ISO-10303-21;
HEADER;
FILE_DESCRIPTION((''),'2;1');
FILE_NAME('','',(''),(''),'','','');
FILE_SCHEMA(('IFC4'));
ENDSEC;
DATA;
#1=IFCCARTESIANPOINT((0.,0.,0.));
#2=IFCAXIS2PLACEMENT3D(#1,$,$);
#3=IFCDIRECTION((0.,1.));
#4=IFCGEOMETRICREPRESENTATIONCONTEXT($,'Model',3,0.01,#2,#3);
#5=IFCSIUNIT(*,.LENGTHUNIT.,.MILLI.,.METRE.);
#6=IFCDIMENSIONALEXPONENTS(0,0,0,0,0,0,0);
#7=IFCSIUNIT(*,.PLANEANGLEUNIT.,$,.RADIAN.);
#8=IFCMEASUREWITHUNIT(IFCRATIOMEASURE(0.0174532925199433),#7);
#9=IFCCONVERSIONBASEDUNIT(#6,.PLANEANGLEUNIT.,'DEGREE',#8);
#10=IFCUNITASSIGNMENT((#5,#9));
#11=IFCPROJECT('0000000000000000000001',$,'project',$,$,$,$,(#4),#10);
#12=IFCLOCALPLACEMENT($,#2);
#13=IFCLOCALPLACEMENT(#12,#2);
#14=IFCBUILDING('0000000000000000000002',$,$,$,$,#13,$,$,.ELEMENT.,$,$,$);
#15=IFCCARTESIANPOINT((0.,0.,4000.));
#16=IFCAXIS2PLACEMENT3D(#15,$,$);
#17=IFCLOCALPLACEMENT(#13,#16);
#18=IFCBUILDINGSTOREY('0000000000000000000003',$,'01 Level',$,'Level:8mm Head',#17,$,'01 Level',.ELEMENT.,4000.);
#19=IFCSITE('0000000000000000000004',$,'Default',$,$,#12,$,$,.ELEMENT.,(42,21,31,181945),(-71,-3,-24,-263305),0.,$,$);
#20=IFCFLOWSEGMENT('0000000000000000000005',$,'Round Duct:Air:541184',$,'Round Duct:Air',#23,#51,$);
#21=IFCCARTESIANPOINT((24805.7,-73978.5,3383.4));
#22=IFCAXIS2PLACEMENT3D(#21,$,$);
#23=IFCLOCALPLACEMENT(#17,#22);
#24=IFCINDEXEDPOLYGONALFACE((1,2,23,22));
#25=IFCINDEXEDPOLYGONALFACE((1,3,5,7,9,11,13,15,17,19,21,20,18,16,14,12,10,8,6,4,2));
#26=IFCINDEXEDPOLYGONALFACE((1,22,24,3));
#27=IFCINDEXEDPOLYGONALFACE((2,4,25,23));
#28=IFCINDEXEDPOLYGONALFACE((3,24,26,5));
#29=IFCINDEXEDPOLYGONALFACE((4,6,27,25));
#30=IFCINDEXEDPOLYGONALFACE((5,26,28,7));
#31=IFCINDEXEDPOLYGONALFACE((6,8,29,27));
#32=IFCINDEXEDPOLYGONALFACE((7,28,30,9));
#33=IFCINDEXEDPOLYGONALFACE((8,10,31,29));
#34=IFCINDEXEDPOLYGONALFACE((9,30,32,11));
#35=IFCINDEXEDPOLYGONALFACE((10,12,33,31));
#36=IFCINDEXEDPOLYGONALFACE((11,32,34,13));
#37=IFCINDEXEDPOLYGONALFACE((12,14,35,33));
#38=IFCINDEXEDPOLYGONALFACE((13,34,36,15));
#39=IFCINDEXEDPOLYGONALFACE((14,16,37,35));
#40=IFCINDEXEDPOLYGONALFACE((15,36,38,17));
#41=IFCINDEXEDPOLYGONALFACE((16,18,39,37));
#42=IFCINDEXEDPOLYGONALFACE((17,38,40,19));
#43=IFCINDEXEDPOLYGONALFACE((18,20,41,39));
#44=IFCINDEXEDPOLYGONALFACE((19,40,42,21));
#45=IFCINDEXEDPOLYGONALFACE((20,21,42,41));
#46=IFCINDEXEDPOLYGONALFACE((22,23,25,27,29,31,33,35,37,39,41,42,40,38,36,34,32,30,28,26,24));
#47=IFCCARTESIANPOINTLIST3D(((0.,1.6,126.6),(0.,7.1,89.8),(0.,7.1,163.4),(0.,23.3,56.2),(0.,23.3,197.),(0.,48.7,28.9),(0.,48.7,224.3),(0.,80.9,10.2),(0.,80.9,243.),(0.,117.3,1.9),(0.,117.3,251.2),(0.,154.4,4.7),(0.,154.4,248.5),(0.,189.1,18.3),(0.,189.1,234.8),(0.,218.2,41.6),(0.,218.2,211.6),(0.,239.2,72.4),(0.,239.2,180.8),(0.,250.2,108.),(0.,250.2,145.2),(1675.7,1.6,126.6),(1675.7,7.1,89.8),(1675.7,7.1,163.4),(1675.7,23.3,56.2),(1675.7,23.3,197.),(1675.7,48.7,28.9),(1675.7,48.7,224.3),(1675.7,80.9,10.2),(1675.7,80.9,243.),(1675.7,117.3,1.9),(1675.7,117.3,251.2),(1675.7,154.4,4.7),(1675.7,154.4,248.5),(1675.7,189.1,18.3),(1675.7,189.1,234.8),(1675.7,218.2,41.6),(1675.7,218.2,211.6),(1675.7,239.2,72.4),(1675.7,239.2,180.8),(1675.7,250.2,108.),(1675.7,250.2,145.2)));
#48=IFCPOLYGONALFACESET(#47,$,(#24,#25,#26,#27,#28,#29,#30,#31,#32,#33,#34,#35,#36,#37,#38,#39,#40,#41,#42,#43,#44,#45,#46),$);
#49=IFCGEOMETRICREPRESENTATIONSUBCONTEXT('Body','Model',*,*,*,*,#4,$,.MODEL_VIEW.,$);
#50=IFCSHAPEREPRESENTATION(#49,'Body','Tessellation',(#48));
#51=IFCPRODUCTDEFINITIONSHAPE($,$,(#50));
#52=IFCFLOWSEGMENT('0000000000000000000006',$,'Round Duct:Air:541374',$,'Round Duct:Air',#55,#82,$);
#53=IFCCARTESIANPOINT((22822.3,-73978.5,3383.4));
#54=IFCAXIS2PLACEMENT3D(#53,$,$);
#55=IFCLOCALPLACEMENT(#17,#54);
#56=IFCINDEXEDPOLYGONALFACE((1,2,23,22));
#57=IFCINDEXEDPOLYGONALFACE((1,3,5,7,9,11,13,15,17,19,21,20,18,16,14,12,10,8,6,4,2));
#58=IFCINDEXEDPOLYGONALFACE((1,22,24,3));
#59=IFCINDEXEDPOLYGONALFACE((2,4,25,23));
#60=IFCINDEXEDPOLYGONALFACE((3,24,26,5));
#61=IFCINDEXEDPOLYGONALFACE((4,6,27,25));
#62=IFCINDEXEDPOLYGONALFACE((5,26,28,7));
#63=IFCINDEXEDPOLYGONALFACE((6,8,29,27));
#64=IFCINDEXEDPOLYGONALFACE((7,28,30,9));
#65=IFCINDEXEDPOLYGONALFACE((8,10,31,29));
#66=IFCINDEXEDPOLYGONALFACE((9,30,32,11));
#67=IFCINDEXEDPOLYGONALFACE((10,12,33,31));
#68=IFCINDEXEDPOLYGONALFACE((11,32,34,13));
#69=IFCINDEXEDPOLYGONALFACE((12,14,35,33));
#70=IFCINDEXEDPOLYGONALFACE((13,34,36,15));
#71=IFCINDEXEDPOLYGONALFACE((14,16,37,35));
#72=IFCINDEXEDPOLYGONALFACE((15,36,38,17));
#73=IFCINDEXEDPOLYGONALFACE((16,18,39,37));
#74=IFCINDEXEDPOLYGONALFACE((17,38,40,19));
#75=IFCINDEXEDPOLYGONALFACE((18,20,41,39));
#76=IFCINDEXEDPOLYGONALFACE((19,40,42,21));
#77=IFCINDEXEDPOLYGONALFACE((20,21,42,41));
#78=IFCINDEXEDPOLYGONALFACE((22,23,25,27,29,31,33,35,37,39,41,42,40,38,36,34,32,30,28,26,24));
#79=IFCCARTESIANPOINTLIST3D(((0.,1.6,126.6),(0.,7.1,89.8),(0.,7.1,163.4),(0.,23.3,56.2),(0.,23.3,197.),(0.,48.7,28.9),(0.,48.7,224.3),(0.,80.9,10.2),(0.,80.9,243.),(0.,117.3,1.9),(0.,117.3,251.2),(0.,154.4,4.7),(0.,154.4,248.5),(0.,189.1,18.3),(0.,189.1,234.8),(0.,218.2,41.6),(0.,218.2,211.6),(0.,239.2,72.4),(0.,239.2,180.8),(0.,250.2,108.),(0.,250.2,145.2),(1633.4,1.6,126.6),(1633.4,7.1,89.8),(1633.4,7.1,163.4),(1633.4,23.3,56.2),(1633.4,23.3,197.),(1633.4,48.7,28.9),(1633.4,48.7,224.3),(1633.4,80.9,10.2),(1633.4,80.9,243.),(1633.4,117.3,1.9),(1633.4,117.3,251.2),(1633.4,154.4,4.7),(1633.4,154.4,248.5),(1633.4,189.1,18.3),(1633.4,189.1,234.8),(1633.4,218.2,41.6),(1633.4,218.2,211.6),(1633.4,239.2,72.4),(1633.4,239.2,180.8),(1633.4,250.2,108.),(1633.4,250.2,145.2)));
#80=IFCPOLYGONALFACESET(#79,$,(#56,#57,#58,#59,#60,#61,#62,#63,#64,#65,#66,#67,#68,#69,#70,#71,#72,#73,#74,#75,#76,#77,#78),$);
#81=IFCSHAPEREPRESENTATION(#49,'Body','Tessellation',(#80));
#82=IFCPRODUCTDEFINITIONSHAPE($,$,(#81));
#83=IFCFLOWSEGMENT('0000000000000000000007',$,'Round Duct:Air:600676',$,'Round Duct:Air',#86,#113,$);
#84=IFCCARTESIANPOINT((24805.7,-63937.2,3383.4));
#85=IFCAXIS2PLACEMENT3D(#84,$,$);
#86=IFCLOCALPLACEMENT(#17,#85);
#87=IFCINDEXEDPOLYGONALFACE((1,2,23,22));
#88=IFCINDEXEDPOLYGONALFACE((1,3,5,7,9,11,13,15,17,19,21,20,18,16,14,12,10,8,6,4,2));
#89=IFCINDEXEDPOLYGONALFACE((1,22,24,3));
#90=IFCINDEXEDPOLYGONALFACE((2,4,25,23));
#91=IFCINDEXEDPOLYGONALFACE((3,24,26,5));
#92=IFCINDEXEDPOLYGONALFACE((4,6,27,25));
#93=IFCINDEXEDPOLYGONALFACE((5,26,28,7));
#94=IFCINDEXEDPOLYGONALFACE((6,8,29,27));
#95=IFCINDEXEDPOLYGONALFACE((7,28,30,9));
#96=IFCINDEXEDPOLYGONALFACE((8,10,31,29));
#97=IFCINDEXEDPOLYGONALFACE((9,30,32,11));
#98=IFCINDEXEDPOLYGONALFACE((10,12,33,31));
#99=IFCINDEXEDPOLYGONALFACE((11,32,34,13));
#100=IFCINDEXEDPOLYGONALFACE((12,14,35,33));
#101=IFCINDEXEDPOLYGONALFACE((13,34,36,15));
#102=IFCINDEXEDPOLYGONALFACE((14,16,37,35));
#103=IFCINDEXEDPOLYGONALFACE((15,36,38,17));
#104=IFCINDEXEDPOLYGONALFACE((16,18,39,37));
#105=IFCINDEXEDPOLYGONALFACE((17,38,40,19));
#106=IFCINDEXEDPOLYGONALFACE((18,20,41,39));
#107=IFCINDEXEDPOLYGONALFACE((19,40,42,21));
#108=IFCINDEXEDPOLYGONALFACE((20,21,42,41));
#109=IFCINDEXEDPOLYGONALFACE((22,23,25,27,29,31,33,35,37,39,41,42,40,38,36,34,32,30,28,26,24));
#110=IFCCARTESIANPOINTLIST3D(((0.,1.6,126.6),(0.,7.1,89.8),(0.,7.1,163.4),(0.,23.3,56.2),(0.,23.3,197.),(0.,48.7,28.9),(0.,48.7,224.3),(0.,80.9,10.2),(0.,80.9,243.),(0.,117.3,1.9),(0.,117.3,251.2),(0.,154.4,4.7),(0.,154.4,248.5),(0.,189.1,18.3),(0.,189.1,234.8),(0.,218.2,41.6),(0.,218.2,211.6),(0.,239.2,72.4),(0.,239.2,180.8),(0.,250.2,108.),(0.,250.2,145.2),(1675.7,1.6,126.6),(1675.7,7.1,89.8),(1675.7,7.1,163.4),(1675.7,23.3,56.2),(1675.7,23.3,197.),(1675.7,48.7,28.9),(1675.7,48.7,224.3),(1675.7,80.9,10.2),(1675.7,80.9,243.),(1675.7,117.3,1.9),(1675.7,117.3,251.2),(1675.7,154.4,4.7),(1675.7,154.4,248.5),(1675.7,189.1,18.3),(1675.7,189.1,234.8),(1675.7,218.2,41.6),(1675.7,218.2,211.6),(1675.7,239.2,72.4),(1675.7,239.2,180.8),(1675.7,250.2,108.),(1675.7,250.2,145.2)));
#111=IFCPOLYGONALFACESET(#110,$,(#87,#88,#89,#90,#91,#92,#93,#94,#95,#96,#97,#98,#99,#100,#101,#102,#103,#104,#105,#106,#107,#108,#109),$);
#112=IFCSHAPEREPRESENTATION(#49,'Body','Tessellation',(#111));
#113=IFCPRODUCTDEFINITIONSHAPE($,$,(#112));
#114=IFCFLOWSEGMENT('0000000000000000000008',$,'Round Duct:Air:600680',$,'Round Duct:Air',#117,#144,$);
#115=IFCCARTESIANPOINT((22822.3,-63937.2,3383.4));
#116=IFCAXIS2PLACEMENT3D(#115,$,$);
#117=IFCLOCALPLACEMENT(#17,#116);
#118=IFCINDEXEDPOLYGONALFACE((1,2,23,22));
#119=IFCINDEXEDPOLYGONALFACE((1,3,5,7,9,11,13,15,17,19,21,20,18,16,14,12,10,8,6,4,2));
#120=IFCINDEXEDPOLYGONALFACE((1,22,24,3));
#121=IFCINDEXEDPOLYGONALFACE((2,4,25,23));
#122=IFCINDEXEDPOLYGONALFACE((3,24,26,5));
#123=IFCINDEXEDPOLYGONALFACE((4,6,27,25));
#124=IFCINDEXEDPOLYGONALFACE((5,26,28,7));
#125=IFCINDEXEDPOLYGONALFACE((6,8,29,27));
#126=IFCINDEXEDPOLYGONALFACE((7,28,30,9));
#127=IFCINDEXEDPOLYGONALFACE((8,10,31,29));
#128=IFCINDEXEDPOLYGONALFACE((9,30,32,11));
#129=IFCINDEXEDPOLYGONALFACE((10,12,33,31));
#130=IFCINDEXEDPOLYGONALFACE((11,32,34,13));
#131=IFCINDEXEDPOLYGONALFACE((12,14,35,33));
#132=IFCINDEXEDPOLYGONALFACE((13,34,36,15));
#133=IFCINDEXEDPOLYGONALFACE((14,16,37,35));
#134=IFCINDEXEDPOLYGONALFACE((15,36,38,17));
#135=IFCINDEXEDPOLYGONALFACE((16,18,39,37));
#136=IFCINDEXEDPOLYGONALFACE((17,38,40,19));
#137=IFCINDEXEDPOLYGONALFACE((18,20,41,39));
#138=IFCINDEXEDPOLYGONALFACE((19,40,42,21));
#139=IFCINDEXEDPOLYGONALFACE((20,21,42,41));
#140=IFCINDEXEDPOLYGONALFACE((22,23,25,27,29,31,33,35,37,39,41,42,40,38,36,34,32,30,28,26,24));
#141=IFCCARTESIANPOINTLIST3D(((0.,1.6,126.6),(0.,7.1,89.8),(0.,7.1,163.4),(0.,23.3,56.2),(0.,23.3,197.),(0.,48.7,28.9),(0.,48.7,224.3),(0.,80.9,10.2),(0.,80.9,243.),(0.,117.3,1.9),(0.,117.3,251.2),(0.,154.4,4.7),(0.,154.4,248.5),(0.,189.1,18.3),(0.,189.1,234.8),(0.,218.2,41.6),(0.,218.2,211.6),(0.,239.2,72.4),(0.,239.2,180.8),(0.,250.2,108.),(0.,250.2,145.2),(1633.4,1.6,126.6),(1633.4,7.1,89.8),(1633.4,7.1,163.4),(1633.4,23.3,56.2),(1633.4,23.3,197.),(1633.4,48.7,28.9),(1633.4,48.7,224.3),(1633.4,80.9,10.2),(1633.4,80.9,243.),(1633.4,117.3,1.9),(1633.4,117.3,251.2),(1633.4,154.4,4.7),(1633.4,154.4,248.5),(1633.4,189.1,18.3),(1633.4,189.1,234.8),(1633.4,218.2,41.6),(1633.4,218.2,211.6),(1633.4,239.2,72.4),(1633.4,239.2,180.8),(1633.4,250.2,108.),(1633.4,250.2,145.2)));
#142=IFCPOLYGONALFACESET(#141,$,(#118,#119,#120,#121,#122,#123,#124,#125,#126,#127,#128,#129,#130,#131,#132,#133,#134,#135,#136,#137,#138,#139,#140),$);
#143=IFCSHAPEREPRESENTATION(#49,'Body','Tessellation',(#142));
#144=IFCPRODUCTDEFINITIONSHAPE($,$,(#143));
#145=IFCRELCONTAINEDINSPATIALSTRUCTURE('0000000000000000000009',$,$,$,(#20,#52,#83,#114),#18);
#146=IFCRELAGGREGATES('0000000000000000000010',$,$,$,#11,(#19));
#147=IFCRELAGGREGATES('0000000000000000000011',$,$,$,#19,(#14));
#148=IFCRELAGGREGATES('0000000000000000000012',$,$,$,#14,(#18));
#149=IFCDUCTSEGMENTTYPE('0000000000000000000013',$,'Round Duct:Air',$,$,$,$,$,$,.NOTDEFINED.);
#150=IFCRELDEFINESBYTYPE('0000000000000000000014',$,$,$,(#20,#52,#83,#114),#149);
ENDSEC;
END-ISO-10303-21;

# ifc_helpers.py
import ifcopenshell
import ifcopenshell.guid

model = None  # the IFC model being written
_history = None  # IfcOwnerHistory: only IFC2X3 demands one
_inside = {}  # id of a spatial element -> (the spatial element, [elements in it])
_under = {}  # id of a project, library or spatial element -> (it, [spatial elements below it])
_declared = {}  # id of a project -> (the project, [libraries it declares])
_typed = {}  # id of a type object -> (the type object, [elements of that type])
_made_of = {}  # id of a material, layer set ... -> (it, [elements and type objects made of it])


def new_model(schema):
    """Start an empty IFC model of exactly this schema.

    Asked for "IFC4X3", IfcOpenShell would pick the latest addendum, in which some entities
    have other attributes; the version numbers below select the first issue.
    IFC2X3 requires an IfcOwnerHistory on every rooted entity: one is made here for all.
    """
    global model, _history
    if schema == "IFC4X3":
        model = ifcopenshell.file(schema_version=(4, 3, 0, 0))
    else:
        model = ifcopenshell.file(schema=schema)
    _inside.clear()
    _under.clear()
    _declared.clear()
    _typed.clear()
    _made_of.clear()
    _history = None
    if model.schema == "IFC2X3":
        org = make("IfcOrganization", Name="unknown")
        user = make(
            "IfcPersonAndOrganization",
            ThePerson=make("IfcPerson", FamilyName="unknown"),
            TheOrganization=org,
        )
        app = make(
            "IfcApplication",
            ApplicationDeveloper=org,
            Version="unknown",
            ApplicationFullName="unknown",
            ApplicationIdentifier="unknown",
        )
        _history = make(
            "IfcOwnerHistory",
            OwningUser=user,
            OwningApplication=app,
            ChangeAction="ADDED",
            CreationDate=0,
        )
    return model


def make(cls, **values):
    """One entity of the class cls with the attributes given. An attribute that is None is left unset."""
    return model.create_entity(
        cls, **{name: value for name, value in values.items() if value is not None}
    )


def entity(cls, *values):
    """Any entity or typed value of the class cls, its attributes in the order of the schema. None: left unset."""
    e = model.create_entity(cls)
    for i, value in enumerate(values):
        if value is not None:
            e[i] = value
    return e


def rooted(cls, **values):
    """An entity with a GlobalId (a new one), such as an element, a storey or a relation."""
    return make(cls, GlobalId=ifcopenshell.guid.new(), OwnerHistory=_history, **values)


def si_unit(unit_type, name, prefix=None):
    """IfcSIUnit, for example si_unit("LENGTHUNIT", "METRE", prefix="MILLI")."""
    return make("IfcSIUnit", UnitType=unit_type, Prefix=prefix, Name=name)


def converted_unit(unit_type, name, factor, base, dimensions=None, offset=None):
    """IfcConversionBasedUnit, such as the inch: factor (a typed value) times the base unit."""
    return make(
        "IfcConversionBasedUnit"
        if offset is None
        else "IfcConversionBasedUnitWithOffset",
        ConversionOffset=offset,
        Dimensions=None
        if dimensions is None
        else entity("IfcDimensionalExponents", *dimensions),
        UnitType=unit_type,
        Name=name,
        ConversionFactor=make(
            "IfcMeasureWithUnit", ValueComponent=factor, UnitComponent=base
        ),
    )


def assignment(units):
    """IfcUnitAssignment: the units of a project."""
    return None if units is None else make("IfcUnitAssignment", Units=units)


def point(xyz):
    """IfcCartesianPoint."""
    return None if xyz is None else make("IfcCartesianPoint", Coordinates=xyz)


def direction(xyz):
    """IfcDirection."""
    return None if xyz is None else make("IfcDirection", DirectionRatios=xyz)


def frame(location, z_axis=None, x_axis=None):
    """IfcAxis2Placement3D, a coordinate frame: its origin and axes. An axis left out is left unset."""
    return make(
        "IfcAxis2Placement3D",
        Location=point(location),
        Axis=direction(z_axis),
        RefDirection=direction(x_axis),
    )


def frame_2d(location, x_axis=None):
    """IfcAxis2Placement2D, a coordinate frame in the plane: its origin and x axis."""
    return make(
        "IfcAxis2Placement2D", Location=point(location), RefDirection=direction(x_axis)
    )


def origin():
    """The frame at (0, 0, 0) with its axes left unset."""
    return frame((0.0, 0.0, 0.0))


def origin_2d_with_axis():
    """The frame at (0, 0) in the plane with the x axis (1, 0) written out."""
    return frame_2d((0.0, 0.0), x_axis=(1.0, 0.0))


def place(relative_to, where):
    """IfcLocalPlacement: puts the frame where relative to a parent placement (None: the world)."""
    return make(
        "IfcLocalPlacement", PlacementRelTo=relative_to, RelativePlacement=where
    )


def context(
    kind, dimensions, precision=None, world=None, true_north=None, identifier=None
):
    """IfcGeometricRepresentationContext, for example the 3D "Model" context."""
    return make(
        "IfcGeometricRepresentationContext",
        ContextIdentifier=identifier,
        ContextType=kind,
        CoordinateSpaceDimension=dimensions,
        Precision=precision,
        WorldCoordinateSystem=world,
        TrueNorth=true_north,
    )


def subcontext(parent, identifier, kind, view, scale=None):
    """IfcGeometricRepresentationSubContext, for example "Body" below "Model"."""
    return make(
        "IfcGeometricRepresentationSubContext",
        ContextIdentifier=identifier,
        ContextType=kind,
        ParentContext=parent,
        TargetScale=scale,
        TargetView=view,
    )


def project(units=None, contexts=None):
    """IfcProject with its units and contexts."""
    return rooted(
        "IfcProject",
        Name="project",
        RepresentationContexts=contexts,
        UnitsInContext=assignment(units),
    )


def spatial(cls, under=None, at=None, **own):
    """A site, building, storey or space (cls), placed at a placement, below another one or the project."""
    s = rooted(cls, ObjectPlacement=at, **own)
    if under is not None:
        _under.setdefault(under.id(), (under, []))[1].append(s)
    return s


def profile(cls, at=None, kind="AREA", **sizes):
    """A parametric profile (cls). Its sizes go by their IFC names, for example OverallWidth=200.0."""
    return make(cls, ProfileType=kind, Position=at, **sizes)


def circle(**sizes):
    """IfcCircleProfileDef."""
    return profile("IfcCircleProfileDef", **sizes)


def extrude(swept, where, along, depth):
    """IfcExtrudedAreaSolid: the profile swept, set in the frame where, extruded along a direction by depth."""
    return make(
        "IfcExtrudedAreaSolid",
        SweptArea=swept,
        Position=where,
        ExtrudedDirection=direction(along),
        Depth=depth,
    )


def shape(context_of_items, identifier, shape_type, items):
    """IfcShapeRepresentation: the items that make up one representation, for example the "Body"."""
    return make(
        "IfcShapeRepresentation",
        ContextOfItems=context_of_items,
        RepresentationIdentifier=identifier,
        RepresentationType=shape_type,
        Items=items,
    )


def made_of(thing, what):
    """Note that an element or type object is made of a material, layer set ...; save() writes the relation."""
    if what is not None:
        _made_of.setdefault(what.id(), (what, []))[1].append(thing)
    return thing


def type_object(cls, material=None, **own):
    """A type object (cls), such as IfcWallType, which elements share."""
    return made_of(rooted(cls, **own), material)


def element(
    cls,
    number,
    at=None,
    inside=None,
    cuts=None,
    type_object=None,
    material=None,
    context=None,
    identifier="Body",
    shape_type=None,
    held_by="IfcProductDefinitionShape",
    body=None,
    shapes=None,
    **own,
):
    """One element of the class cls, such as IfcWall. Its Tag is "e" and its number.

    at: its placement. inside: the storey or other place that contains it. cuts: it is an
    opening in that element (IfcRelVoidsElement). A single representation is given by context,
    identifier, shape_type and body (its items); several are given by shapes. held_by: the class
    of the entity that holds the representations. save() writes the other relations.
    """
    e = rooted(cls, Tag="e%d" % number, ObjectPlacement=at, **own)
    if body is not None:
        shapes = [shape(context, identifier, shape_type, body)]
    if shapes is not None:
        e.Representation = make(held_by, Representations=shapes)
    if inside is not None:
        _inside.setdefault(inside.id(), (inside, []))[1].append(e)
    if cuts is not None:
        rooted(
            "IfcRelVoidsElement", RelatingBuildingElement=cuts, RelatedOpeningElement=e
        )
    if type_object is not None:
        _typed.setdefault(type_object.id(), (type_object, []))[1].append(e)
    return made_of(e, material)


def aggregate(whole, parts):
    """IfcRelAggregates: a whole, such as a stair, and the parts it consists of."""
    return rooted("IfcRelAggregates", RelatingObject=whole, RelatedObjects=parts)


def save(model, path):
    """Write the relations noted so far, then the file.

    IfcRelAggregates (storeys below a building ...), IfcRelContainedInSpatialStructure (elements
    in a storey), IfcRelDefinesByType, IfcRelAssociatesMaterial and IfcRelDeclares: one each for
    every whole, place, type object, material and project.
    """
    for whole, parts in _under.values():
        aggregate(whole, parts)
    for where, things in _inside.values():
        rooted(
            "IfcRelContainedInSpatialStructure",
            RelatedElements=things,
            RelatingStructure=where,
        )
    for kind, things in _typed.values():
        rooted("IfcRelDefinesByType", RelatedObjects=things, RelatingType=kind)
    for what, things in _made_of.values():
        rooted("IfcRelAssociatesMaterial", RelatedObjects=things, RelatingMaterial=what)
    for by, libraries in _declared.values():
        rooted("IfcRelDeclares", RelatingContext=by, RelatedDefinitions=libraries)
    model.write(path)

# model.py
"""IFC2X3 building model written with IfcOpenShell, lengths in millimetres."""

from ifc_helpers import new_model, entity, si_unit, converted_unit, direction, frame, origin, origin_2d_with_axis, place, context, subcontext, project, spatial, circle, extrude, type_object, element, save


model = new_model("IFC2X3")

# Units and contexts
model_context = context("Model", 3, precision=0.01, world=origin(), true_north=direction((0.0, 1.0)))
body_context = subcontext(model_context, "Body", "Model", "MODEL_VIEW")
ifc_project = project(units=[si_unit("LENGTHUNIT", "METRE", prefix="MILLI"), converted_unit("PLANEANGLEUNIT", "DEGREE", entity("IfcRatioMeasure", 0.0174532925199433), si_unit("PLANEANGLEUNIT", "RADIAN"), dimensions=[0, 0, 0, 0, 0, 0, 0])], contexts=[model_context])

# Site, building, storey
site_placement = place(None, origin())
site = spatial("IfcSite", under=ifc_project, at=site_placement, Name="Default", CompositionType="ELEMENT", RefLatitude=(42, 21, 31, 181945), RefLongitude=(-71, -3, -24, -263305), RefElevation=0.0)
building_placement = place(site_placement, origin())
building = spatial("IfcBuilding", under=site, at=building_placement, CompositionType="ELEMENT")
storey_placement = place(building_placement, frame((0.0, 0.0, 4000.0)))
storey = spatial("IfcBuildingStorey", under=building, at=storey_placement, Name="01 Level", ObjectType="Level:8mm Head", LongName="01 Level", CompositionType="ELEMENT", Elevation=4000.0)

# Flow segments
duct_segment_type_1 = type_object("IfcDuctSegmentType", Name="Round Duct:Air", PredefinedType="NOTDEFINED")
flow_segment_1_placement = place(storey_placement, frame((24805.7, -73978.5, 3383.4)))
element("IfcFlowSegment", 1, at=flow_segment_1_placement, inside=storey, type_object=duct_segment_type_1, Name="Round Duct:Air:541184", ObjectType="Round Duct:Air", context=body_context, shape_type="SweptSolid", body=[
    extrude(circle(Radius=125.0, at=origin_2d_with_axis()), frame((0.0, 126.6, 126.6), z_axis=(1.0, 0.0, 0.0), x_axis=(0.0, -1.0, 0.0)), (0.0, 0.0, 1.0), 1675.7),
])
flow_segment_2_placement = place(storey_placement, frame((22822.3, -73978.5, 3383.4)))
element("IfcFlowSegment", 2, at=flow_segment_2_placement, inside=storey, type_object=duct_segment_type_1, Name="Round Duct:Air:541374", ObjectType="Round Duct:Air", context=body_context, shape_type="SweptSolid", body=[
    extrude(circle(Radius=125.0, at=origin_2d_with_axis()), frame((0.0, 126.6, 126.6), z_axis=(1.0, 0.0, 0.0), x_axis=(0.0, -1.0, 0.0)), (0.0, 0.0, 1.0), 1633.4),
])
flow_segment_3_placement = place(storey_placement, frame((24805.7, -63937.2, 3383.4)))
element("IfcFlowSegment", 3, at=flow_segment_3_placement, inside=storey, type_object=duct_segment_type_1, Name="Round Duct:Air:600676", ObjectType="Round Duct:Air", context=body_context, shape_type="SweptSolid", body=[
    extrude(circle(Radius=125.0, at=origin_2d_with_axis()), frame((0.0, 126.6, 126.6), z_axis=(1.0, 0.0, 0.0), x_axis=(0.0, -1.0, 0.0)), (0.0, 0.0, 1.0), 1675.7),
])
flow_segment_4_placement = place(storey_placement, frame((22822.3, -63937.2, 3383.4)))
element("IfcFlowSegment", 4, at=flow_segment_4_placement, inside=storey, type_object=duct_segment_type_1, Name="Round Duct:Air:600680", ObjectType="Round Duct:Air", context=body_context, shape_type="SweptSolid", body=[
    extrude(circle(Radius=125.0, at=origin_2d_with_axis()), frame((0.0, 126.6, 126.6), z_axis=(1.0, 0.0, 0.0), x_axis=(0.0, -1.0, 0.0)), (0.0, 0.0, 1.0), 1633.4),
])

save(model, "model.ifc")
